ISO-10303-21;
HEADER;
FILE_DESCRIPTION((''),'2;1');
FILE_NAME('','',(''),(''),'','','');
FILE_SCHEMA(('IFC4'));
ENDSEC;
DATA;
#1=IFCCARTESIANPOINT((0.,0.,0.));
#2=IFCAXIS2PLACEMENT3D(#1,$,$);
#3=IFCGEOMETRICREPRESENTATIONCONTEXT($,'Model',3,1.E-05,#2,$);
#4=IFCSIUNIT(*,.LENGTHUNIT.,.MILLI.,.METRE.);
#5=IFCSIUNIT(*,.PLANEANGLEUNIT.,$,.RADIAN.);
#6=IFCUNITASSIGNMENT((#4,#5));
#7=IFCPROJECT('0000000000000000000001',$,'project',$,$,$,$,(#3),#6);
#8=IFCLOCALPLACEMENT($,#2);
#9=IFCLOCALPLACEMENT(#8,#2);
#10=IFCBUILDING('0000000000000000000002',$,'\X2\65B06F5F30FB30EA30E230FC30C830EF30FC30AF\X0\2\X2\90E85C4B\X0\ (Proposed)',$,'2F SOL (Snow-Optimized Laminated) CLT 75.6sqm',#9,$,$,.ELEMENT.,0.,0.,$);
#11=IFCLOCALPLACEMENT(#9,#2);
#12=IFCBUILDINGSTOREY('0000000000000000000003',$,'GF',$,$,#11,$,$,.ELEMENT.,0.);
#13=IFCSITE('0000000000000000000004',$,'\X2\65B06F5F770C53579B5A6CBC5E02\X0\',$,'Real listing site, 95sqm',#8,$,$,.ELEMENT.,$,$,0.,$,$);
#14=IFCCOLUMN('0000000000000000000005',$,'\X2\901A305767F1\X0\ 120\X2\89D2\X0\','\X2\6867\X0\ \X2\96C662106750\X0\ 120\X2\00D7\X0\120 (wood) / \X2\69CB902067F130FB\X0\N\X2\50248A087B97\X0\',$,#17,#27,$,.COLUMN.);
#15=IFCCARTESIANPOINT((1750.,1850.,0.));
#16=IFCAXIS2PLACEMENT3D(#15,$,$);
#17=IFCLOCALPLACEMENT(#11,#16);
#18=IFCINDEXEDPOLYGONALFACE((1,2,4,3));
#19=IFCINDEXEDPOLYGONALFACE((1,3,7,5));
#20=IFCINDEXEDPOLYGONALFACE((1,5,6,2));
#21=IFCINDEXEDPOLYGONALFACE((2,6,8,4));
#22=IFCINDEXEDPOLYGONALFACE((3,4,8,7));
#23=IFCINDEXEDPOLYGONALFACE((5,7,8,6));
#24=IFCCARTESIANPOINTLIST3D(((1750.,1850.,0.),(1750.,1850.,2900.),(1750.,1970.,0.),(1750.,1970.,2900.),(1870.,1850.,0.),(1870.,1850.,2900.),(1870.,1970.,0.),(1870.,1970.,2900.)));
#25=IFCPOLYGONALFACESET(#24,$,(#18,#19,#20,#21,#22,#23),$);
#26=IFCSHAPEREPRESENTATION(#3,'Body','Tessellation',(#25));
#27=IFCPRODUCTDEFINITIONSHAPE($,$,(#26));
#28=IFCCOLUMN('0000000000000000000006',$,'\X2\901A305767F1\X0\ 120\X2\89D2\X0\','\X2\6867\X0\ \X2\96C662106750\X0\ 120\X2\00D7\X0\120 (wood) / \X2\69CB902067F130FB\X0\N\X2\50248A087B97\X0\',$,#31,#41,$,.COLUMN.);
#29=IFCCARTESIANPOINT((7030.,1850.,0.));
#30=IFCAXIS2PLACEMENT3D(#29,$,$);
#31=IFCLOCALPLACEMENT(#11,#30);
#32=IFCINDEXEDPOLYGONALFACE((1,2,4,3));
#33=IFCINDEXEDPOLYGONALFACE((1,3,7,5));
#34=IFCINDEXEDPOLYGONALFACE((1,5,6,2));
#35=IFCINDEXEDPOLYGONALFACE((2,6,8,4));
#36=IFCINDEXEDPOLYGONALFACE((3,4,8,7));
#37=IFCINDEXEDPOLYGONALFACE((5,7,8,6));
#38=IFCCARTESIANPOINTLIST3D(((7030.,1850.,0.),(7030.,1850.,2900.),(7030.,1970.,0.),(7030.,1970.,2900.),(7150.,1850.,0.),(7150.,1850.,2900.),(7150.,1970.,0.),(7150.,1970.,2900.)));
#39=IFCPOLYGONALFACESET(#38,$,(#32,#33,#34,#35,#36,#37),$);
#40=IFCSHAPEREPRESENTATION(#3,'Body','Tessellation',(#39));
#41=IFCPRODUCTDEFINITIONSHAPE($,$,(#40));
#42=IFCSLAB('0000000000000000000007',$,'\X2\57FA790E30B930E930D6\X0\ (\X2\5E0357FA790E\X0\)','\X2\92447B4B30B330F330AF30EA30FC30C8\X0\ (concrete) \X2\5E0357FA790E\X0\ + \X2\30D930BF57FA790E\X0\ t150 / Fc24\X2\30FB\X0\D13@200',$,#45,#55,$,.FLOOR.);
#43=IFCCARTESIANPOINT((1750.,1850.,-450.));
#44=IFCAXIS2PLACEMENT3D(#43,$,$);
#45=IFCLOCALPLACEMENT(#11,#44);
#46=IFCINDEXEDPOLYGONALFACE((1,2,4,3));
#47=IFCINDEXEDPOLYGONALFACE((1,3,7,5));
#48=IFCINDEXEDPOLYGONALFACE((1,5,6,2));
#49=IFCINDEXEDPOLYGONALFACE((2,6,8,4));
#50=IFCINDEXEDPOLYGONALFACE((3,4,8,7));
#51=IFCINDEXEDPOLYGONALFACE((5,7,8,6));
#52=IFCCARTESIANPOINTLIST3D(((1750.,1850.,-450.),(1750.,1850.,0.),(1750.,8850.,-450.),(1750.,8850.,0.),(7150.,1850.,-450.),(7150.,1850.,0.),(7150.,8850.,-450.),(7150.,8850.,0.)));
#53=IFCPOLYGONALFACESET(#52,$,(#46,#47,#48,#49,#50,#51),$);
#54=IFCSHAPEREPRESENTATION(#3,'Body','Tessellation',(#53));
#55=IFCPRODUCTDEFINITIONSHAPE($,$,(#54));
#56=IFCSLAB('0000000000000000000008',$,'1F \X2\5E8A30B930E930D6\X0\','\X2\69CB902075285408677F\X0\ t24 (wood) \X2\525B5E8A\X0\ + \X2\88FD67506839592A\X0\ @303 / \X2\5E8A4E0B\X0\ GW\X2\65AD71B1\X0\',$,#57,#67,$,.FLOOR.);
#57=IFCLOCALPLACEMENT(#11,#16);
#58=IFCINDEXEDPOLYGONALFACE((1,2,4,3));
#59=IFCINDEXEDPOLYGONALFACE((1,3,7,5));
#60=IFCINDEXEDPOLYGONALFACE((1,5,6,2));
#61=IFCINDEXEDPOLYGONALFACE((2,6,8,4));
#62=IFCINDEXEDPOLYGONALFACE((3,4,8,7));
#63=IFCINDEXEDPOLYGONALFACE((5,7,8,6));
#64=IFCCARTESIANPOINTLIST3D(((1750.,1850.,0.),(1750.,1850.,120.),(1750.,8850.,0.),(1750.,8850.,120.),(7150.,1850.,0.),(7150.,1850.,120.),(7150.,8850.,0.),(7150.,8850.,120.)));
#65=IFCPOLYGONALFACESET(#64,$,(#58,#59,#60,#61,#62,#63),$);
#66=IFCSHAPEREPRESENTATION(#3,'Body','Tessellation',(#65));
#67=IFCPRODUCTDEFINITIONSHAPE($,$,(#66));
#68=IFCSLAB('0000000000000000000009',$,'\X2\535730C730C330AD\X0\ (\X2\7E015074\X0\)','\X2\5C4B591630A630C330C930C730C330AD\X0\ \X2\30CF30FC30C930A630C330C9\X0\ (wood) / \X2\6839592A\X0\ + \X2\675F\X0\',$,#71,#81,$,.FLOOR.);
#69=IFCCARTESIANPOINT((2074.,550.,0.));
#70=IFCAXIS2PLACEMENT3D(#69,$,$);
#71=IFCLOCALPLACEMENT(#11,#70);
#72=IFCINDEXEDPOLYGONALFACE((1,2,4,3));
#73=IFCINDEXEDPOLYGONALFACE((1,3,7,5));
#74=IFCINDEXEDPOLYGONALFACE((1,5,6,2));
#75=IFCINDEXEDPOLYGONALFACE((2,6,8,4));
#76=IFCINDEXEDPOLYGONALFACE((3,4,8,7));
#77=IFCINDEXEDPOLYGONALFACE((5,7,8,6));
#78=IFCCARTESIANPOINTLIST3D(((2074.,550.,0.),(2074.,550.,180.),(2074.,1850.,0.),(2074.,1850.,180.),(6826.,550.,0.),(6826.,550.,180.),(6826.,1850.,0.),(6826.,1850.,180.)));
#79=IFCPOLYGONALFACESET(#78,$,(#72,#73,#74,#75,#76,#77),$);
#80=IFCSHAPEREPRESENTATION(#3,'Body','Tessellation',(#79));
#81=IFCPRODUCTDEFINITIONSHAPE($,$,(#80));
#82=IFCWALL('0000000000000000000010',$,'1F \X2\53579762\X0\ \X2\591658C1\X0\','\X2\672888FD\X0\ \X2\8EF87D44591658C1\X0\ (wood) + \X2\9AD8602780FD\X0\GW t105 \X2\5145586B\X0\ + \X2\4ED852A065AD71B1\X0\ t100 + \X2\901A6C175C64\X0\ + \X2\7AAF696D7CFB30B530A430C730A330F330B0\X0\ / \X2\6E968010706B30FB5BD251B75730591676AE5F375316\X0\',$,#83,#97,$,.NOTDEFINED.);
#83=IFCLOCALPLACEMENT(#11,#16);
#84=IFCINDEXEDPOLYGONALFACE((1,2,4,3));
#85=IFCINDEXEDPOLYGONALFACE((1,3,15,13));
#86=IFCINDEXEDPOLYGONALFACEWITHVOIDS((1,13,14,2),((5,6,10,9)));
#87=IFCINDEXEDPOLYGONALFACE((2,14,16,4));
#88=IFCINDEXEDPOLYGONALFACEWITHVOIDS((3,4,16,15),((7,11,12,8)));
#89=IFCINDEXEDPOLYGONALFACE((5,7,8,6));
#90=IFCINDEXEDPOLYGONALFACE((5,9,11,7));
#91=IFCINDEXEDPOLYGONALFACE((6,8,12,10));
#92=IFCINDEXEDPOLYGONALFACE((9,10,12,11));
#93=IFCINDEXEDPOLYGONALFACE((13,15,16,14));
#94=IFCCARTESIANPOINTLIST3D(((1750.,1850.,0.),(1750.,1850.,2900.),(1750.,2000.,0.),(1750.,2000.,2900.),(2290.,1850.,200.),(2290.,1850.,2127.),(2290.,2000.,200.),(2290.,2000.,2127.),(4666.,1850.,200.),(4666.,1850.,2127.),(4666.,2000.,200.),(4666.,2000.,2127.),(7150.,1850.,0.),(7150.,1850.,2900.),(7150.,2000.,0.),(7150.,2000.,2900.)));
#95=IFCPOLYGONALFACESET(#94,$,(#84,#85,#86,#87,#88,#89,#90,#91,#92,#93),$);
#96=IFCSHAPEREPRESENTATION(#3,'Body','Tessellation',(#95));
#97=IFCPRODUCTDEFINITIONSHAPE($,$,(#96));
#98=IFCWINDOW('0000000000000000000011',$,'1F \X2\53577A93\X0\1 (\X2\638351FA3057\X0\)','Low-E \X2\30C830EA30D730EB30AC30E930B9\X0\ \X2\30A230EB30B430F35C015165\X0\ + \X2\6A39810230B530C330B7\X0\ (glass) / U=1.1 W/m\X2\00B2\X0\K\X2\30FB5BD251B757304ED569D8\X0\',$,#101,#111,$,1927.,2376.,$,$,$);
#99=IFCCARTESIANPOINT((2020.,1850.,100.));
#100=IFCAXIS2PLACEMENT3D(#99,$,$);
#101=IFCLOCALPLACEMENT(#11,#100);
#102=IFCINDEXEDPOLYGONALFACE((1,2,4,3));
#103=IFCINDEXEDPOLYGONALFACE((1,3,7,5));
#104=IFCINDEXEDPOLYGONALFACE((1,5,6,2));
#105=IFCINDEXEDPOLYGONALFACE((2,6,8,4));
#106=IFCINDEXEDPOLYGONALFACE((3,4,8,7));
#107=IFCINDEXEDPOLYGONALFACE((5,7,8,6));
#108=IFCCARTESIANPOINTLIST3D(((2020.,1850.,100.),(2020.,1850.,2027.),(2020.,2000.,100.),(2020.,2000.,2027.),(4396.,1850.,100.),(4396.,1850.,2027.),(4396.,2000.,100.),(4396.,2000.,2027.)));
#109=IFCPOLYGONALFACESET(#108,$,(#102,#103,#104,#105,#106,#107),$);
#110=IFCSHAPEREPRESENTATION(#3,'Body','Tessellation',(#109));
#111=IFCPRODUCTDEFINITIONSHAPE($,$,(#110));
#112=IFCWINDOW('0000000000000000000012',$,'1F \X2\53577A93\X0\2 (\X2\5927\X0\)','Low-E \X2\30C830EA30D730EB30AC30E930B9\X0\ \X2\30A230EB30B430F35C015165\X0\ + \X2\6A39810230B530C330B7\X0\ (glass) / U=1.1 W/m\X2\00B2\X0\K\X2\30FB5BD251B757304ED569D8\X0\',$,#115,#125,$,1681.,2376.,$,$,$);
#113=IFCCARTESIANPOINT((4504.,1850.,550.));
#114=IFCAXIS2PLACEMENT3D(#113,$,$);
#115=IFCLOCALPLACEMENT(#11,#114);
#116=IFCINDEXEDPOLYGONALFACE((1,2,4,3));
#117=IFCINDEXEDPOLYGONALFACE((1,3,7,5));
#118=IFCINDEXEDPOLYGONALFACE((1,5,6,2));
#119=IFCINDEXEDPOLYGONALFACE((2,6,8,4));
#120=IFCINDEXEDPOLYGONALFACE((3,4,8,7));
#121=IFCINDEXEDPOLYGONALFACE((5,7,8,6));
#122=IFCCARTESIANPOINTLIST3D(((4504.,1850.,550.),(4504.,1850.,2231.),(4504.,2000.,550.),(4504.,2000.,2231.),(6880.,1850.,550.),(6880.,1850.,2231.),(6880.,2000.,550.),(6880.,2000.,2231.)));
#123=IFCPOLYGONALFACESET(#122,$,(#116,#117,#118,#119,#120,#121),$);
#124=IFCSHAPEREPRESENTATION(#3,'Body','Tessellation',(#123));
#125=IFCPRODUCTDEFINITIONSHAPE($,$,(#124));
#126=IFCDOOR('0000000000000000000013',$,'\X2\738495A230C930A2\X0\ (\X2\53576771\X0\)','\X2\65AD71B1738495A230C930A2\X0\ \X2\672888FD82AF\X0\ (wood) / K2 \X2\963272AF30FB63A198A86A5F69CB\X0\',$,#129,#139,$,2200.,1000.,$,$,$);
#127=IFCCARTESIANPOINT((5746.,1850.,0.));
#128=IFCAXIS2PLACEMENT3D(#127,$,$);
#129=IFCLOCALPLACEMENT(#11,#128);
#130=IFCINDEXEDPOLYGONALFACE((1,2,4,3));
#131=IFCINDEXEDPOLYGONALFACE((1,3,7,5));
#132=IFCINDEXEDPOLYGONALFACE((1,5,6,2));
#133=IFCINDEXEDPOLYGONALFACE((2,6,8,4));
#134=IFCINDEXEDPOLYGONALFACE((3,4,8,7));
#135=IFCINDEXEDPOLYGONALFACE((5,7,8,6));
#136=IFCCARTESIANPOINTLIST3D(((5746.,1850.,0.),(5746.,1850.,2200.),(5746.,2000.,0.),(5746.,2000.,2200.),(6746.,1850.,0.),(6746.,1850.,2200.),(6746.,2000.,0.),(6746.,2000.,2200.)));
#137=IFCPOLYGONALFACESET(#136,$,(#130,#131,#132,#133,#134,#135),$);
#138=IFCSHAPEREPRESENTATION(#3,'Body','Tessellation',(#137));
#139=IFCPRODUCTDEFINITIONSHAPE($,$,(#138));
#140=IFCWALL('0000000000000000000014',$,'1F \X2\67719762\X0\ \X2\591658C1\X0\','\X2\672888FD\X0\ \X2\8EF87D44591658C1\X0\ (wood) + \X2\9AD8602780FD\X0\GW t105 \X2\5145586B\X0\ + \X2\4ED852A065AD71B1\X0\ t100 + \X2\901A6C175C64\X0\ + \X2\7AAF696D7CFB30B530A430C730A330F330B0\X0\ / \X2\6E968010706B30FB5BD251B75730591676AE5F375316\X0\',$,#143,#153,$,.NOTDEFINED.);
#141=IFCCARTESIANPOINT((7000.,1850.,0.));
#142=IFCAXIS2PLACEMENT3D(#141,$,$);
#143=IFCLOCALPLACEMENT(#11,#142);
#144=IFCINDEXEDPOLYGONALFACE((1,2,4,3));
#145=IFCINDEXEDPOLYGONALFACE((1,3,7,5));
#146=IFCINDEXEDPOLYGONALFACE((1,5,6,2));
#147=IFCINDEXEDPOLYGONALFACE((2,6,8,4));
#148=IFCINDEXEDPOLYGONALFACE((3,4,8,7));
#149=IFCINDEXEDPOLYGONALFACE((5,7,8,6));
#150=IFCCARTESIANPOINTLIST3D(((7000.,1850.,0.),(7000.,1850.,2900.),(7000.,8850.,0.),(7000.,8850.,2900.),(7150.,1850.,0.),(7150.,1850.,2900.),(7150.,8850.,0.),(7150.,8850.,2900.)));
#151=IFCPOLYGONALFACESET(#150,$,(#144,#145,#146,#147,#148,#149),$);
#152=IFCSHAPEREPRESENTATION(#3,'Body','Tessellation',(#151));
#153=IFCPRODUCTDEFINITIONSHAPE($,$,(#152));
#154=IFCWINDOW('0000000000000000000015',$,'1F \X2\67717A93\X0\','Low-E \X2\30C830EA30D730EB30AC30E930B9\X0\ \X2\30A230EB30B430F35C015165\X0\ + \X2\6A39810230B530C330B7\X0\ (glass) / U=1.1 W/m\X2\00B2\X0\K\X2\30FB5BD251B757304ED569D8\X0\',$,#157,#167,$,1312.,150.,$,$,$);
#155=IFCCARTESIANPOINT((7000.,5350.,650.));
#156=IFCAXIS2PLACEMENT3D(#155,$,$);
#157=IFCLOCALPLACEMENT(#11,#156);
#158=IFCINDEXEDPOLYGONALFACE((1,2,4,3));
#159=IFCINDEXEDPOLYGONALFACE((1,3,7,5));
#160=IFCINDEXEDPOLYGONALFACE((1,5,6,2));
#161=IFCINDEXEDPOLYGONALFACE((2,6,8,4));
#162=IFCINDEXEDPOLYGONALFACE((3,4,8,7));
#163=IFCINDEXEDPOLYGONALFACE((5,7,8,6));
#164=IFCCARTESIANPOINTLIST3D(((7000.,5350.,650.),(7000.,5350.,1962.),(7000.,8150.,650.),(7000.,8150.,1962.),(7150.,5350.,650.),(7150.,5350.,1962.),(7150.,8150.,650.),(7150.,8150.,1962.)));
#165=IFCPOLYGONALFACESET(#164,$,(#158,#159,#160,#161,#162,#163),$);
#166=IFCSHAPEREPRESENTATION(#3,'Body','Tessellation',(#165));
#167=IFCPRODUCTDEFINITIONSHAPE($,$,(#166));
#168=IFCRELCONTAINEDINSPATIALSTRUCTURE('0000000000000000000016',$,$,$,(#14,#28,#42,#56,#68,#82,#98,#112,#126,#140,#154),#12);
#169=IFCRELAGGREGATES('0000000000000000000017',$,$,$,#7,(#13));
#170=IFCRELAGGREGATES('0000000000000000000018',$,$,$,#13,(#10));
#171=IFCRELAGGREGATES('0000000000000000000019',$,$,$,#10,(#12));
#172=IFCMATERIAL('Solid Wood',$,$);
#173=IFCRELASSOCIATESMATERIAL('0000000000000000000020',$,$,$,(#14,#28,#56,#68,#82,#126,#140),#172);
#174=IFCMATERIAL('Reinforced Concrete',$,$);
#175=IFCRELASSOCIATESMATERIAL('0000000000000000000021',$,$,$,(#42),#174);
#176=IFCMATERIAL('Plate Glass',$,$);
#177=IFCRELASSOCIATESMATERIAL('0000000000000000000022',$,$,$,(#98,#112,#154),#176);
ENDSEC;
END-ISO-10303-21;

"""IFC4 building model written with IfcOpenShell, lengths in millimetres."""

from ifc_helpers import new_model, si_unit, frame, frame_2d, origin, place, context, project, spatial, rectangle, extrude, material, element, fill, save


model = new_model("IFC4")

# Units and contexts
model_context = context("Model", 3, precision=1e-05, world=origin())
ifc_project = project(units=[si_unit("LENGTHUNIT", "METRE", prefix="MILLI"), si_unit("PLANEANGLEUNIT", "RADIAN")], contexts=[model_context])

# Site, building, storey
site_placement = place(None, origin())
site = spatial("IfcSite", under=ifc_project, at=site_placement, Name="新潟県南魚沼市", ObjectType="Real listing site, 95sqm", CompositionType="ELEMENT", RefElevation=0.0)
building_placement = place(site_placement, origin())
building = spatial("IfcBuilding", under=site, at=building_placement, Name="新潟・リモートワーク2部屋 (Proposed)", ObjectType="2F SOL (Snow-Optimized Laminated) CLT 75.6sqm", CompositionType="ELEMENT", ElevationOfRefHeight=0.0, ElevationOfTerrain=0.0)
storey_placement = place(building_placement, origin())
storey = spatial("IfcBuildingStorey", under=building, at=storey_placement, Name="GF", CompositionType="ELEMENT", Elevation=0.0)

# Columns
ifc_material_1 = material(Name="Solid Wood")
column_1_placement = place(storey_placement, frame((1750.0, 1850.0, 0.0)))
element("IfcColumn", 1, at=column_1_placement, inside=storey, material=ifc_material_1, Name="通し柱 120角", Description="桧 集成材 120×120 (wood) / 構造柱・N値計算", PredefinedType="COLUMN", context=model_context, shape_type="SweptSolid", body=[
    extrude(rectangle(XDim=120.0, YDim=120.0, at=frame_2d((60.0, 60.0))), frame((1750.0, 1850.0, 0.0)), (0.0, 0.0, 1.0), 2900.0),
])
column_2_placement = place(storey_placement, frame((7030.0, 1850.0, 0.0)))
element("IfcColumn", 2, at=column_2_placement, inside=storey, material=ifc_material_1, Name="通し柱 120角", Description="桧 集成材 120×120 (wood) / 構造柱・N値計算", PredefinedType="COLUMN", context=model_context, shape_type="SweptSolid", body=[
    extrude(rectangle(XDim=120.0, YDim=120.0, at=frame_2d((60.0, 60.0))), frame((7030.0, 1850.0, 0.0)), (0.0, 0.0, 1.0), 2900.0),
])

# Slabs
ifc_material_2 = material(Name="Reinforced Concrete")
slab_1_placement = place(storey_placement, frame((1750.0, 1850.0, -450.0)))
element("IfcSlab", 3, at=slab_1_placement, inside=storey, material=ifc_material_2, Name="基礎スラブ (布基礎)", Description="鉄筋コンクリート (concrete) 布基礎 + ベタ基礎 t150 / Fc24・D13@200", PredefinedType="FLOOR", context=model_context, shape_type="SweptSolid", body=[
    extrude(rectangle(XDim=5400.0, YDim=7000.0, at=frame_2d((2700.0, 3500.0))), frame((1750.0, 1850.0, -450.0)), (0.0, 0.0, 1.0), 450.0),
])
slab_2_placement = place(storey_placement, frame((1750.0, 1850.0, 0.0)))
element("IfcSlab", 4, at=slab_2_placement, inside=storey, material=ifc_material_1, Name="1F 床スラブ", Description="構造用合板 t24 (wood) 剛床 + 製材根太 @303 / 床下 GW断熱", PredefinedType="FLOOR", context=model_context, shape_type="SweptSolid", body=[
    extrude(rectangle(XDim=5400.0, YDim=7000.0, at=frame_2d((2700.0, 3500.0))), frame((1750.0, 1850.0, 0.0)), (0.0, 0.0, 1.0), 120.0),
])
slab_3_placement = place(storey_placement, frame((2074.0, 550.0, 0.0)))
element("IfcSlab", 5, at=slab_3_placement, inside=storey, material=ifc_material_1, Name="南デッキ (縁側)", Description="屋外ウッドデッキ ハードウッド (wood) / 根太 + 束", PredefinedType="FLOOR", context=model_context, shape_type="SweptSolid", body=[
    extrude(rectangle(XDim=4752.0, YDim=1300.0, at=frame_2d((2376.0, 650.0))), frame((2074.0, 550.0, 0.0)), (0.0, 0.0, 1.0), 180.0),
])

# Wall, openings, windows, door
wall_1_placement = place(storey_placement, frame((1750.0, 1850.0, 0.0)))
wall_1 = element("IfcWall", 6, at=wall_1_placement, inside=storey, material=ifc_material_1, Name="1F 南面 外壁", Description="木製 軸組外壁 (wood) + 高性能GW t105 充填 + 付加断熱 t100 + 通気層 + 窯業系サイディング / 準耐火・寒冷地外皮強化", PredefinedType="NOTDEFINED", context=model_context, shape_type="SweptSolid", body=[
    extrude(rectangle(XDim=5400.0, YDim=150.0, at=frame_2d((2700.0, 75.0))), frame((1750.0, 1850.0, 0.0)), (0.0, 0.0, 1.0), 2900.0),
])
opening_1_placement = place(storey_placement, frame((2020.0, 1850.0, 100.0)))
opening_1 = element("IfcOpeningElement", 7, at=opening_1_placement, cuts=wall_1, PredefinedType="NOTDEFINED", context=model_context, shape_type="SweptSolid", body=[
    extrude(rectangle(XDim=2376.0, YDim=150.0, at=frame_2d((1188.0, 75.0))), frame((2020.0, 1850.0, 100.0)), (0.0, 0.0, 1.0), 1927.0),
])
opening_2_placement = place(storey_placement, frame((4504.0, 1850.0, 550.0)))
opening_2 = element("IfcOpeningElement", 8, at=opening_2_placement, cuts=wall_1, PredefinedType="NOTDEFINED", context=model_context, shape_type="SweptSolid", body=[
    extrude(rectangle(XDim=2376.0, YDim=150.0, at=frame_2d((1188.0, 75.0))), frame((4504.0, 1850.0, 550.0)), (0.0, 0.0, 1.0), 1681.0),
])
opening_3_placement = place(storey_placement, frame((5746.0, 1850.0, 0.0)))
opening_3 = element("IfcOpeningElement", 9, at=opening_3_placement, cuts=wall_1, PredefinedType="NOTDEFINED", context=model_context, shape_type="SweptSolid", body=[
    extrude(rectangle(XDim=1000.0, YDim=150.0, at=frame_2d((500.0, 75.0))), frame((5746.0, 1850.0, 0.0)), (0.0, 0.0, 1.0), 2200.0),
])
ifc_material_3 = material(Name="Plate Glass")
window_1_placement = place(storey_placement, frame((2020.0, 1850.0, 100.0)))
window_1 = element("IfcWindow", 10, at=window_1_placement, inside=storey, material=ifc_material_3, Name="1F 南窓1 (掃出し)", Description="Low-E トリプルガラス アルゴン封入 + 樹脂サッシ (glass) / U=1.1 W/m²K・寒冷地仕様", OverallHeight=1927.0, OverallWidth=2376.0, context=model_context, shape_type="SweptSolid", body=[
    extrude(rectangle(XDim=2376.0, YDim=150.0, at=frame_2d((1188.0, 75.0))), frame((2020.0, 1850.0, 100.0)), (0.0, 0.0, 1.0), 1927.0),
])
fill(opening_1, window_1)
window_2_placement = place(storey_placement, frame((4504.0, 1850.0, 550.0)))
window_2 = element("IfcWindow", 11, at=window_2_placement, inside=storey, material=ifc_material_3, Name="1F 南窓2 (大)", Description="Low-E トリプルガラス アルゴン封入 + 樹脂サッシ (glass) / U=1.1 W/m²K・寒冷地仕様", OverallHeight=1681.0, OverallWidth=2376.0, context=model_context, shape_type="SweptSolid", body=[
    extrude(rectangle(XDim=2376.0, YDim=150.0, at=frame_2d((1188.0, 75.0))), frame((4504.0, 1850.0, 550.0)), (0.0, 0.0, 1.0), 1681.0),
])
fill(opening_2, window_2)
door_placement = place(storey_placement, frame((5746.0, 1850.0, 0.0)))
door = element("IfcDoor", 12, at=door_placement, inside=storey, material=ifc_material_1, Name="玄関ドア (南東)", Description="断熱玄関ドア 木製芯 (wood) / K2 防犯・採風機構", OverallHeight=2200.0, OverallWidth=1000.0, context=model_context, shape_type="SweptSolid", body=[
    extrude(rectangle(XDim=1000.0, YDim=150.0, at=frame_2d((500.0, 75.0))), frame((5746.0, 1850.0, 0.0)), (0.0, 0.0, 1.0), 2200.0),
])
fill(opening_3, door)

# Wall, opening, window
wall_2_placement = place(storey_placement, frame((7000.0, 1850.0, 0.0)))
wall_2 = element("IfcWall", 13, at=wall_2_placement, inside=storey, material=ifc_material_1, Name="1F 東面 外壁", Description="木製 軸組外壁 (wood) + 高性能GW t105 充填 + 付加断熱 t100 + 通気層 + 窯業系サイディング / 準耐火・寒冷地外皮強化", PredefinedType="NOTDEFINED", context=model_context, shape_type="SweptSolid", body=[
    extrude(rectangle(XDim=150.0, YDim=7000.0, at=frame_2d((75.0, 3500.0))), frame((7000.0, 1850.0, 0.0)), (0.0, 0.0, 1.0), 2900.0),
])
opening_4_placement = place(storey_placement, frame((7000.0, 5350.0, 650.0)))
opening_4 = element("IfcOpeningElement", 14, at=opening_4_placement, cuts=wall_2, PredefinedType="NOTDEFINED", context=model_context, shape_type="SweptSolid", body=[
    extrude(rectangle(XDim=150.0, YDim=2800.0, at=frame_2d((75.0, 1400.0))), frame((7000.0, 5350.0, 650.0)), (0.0, 0.0, 1.0), 1312.0),
])
window_3_placement = place(storey_placement, frame((7000.0, 5350.0, 650.0)))
window_3 = element("IfcWindow", 15, at=window_3_placement, inside=storey, material=ifc_material_3, Name="1F 東窓", Description="Low-E トリプルガラス アルゴン封入 + 樹脂サッシ (glass) / U=1.1 W/m²K・寒冷地仕様", OverallHeight=1312.0, OverallWidth=150.0, context=model_context, shape_type="SweptSolid", body=[
    extrude(rectangle(XDim=150.0, YDim=2800.0, at=frame_2d((75.0, 1400.0))), frame((7000.0, 5350.0, 650.0)), (0.0, 0.0, 1.0), 1312.0),
])
fill(opening_4, window_3)

save(model, "model.ifc")
